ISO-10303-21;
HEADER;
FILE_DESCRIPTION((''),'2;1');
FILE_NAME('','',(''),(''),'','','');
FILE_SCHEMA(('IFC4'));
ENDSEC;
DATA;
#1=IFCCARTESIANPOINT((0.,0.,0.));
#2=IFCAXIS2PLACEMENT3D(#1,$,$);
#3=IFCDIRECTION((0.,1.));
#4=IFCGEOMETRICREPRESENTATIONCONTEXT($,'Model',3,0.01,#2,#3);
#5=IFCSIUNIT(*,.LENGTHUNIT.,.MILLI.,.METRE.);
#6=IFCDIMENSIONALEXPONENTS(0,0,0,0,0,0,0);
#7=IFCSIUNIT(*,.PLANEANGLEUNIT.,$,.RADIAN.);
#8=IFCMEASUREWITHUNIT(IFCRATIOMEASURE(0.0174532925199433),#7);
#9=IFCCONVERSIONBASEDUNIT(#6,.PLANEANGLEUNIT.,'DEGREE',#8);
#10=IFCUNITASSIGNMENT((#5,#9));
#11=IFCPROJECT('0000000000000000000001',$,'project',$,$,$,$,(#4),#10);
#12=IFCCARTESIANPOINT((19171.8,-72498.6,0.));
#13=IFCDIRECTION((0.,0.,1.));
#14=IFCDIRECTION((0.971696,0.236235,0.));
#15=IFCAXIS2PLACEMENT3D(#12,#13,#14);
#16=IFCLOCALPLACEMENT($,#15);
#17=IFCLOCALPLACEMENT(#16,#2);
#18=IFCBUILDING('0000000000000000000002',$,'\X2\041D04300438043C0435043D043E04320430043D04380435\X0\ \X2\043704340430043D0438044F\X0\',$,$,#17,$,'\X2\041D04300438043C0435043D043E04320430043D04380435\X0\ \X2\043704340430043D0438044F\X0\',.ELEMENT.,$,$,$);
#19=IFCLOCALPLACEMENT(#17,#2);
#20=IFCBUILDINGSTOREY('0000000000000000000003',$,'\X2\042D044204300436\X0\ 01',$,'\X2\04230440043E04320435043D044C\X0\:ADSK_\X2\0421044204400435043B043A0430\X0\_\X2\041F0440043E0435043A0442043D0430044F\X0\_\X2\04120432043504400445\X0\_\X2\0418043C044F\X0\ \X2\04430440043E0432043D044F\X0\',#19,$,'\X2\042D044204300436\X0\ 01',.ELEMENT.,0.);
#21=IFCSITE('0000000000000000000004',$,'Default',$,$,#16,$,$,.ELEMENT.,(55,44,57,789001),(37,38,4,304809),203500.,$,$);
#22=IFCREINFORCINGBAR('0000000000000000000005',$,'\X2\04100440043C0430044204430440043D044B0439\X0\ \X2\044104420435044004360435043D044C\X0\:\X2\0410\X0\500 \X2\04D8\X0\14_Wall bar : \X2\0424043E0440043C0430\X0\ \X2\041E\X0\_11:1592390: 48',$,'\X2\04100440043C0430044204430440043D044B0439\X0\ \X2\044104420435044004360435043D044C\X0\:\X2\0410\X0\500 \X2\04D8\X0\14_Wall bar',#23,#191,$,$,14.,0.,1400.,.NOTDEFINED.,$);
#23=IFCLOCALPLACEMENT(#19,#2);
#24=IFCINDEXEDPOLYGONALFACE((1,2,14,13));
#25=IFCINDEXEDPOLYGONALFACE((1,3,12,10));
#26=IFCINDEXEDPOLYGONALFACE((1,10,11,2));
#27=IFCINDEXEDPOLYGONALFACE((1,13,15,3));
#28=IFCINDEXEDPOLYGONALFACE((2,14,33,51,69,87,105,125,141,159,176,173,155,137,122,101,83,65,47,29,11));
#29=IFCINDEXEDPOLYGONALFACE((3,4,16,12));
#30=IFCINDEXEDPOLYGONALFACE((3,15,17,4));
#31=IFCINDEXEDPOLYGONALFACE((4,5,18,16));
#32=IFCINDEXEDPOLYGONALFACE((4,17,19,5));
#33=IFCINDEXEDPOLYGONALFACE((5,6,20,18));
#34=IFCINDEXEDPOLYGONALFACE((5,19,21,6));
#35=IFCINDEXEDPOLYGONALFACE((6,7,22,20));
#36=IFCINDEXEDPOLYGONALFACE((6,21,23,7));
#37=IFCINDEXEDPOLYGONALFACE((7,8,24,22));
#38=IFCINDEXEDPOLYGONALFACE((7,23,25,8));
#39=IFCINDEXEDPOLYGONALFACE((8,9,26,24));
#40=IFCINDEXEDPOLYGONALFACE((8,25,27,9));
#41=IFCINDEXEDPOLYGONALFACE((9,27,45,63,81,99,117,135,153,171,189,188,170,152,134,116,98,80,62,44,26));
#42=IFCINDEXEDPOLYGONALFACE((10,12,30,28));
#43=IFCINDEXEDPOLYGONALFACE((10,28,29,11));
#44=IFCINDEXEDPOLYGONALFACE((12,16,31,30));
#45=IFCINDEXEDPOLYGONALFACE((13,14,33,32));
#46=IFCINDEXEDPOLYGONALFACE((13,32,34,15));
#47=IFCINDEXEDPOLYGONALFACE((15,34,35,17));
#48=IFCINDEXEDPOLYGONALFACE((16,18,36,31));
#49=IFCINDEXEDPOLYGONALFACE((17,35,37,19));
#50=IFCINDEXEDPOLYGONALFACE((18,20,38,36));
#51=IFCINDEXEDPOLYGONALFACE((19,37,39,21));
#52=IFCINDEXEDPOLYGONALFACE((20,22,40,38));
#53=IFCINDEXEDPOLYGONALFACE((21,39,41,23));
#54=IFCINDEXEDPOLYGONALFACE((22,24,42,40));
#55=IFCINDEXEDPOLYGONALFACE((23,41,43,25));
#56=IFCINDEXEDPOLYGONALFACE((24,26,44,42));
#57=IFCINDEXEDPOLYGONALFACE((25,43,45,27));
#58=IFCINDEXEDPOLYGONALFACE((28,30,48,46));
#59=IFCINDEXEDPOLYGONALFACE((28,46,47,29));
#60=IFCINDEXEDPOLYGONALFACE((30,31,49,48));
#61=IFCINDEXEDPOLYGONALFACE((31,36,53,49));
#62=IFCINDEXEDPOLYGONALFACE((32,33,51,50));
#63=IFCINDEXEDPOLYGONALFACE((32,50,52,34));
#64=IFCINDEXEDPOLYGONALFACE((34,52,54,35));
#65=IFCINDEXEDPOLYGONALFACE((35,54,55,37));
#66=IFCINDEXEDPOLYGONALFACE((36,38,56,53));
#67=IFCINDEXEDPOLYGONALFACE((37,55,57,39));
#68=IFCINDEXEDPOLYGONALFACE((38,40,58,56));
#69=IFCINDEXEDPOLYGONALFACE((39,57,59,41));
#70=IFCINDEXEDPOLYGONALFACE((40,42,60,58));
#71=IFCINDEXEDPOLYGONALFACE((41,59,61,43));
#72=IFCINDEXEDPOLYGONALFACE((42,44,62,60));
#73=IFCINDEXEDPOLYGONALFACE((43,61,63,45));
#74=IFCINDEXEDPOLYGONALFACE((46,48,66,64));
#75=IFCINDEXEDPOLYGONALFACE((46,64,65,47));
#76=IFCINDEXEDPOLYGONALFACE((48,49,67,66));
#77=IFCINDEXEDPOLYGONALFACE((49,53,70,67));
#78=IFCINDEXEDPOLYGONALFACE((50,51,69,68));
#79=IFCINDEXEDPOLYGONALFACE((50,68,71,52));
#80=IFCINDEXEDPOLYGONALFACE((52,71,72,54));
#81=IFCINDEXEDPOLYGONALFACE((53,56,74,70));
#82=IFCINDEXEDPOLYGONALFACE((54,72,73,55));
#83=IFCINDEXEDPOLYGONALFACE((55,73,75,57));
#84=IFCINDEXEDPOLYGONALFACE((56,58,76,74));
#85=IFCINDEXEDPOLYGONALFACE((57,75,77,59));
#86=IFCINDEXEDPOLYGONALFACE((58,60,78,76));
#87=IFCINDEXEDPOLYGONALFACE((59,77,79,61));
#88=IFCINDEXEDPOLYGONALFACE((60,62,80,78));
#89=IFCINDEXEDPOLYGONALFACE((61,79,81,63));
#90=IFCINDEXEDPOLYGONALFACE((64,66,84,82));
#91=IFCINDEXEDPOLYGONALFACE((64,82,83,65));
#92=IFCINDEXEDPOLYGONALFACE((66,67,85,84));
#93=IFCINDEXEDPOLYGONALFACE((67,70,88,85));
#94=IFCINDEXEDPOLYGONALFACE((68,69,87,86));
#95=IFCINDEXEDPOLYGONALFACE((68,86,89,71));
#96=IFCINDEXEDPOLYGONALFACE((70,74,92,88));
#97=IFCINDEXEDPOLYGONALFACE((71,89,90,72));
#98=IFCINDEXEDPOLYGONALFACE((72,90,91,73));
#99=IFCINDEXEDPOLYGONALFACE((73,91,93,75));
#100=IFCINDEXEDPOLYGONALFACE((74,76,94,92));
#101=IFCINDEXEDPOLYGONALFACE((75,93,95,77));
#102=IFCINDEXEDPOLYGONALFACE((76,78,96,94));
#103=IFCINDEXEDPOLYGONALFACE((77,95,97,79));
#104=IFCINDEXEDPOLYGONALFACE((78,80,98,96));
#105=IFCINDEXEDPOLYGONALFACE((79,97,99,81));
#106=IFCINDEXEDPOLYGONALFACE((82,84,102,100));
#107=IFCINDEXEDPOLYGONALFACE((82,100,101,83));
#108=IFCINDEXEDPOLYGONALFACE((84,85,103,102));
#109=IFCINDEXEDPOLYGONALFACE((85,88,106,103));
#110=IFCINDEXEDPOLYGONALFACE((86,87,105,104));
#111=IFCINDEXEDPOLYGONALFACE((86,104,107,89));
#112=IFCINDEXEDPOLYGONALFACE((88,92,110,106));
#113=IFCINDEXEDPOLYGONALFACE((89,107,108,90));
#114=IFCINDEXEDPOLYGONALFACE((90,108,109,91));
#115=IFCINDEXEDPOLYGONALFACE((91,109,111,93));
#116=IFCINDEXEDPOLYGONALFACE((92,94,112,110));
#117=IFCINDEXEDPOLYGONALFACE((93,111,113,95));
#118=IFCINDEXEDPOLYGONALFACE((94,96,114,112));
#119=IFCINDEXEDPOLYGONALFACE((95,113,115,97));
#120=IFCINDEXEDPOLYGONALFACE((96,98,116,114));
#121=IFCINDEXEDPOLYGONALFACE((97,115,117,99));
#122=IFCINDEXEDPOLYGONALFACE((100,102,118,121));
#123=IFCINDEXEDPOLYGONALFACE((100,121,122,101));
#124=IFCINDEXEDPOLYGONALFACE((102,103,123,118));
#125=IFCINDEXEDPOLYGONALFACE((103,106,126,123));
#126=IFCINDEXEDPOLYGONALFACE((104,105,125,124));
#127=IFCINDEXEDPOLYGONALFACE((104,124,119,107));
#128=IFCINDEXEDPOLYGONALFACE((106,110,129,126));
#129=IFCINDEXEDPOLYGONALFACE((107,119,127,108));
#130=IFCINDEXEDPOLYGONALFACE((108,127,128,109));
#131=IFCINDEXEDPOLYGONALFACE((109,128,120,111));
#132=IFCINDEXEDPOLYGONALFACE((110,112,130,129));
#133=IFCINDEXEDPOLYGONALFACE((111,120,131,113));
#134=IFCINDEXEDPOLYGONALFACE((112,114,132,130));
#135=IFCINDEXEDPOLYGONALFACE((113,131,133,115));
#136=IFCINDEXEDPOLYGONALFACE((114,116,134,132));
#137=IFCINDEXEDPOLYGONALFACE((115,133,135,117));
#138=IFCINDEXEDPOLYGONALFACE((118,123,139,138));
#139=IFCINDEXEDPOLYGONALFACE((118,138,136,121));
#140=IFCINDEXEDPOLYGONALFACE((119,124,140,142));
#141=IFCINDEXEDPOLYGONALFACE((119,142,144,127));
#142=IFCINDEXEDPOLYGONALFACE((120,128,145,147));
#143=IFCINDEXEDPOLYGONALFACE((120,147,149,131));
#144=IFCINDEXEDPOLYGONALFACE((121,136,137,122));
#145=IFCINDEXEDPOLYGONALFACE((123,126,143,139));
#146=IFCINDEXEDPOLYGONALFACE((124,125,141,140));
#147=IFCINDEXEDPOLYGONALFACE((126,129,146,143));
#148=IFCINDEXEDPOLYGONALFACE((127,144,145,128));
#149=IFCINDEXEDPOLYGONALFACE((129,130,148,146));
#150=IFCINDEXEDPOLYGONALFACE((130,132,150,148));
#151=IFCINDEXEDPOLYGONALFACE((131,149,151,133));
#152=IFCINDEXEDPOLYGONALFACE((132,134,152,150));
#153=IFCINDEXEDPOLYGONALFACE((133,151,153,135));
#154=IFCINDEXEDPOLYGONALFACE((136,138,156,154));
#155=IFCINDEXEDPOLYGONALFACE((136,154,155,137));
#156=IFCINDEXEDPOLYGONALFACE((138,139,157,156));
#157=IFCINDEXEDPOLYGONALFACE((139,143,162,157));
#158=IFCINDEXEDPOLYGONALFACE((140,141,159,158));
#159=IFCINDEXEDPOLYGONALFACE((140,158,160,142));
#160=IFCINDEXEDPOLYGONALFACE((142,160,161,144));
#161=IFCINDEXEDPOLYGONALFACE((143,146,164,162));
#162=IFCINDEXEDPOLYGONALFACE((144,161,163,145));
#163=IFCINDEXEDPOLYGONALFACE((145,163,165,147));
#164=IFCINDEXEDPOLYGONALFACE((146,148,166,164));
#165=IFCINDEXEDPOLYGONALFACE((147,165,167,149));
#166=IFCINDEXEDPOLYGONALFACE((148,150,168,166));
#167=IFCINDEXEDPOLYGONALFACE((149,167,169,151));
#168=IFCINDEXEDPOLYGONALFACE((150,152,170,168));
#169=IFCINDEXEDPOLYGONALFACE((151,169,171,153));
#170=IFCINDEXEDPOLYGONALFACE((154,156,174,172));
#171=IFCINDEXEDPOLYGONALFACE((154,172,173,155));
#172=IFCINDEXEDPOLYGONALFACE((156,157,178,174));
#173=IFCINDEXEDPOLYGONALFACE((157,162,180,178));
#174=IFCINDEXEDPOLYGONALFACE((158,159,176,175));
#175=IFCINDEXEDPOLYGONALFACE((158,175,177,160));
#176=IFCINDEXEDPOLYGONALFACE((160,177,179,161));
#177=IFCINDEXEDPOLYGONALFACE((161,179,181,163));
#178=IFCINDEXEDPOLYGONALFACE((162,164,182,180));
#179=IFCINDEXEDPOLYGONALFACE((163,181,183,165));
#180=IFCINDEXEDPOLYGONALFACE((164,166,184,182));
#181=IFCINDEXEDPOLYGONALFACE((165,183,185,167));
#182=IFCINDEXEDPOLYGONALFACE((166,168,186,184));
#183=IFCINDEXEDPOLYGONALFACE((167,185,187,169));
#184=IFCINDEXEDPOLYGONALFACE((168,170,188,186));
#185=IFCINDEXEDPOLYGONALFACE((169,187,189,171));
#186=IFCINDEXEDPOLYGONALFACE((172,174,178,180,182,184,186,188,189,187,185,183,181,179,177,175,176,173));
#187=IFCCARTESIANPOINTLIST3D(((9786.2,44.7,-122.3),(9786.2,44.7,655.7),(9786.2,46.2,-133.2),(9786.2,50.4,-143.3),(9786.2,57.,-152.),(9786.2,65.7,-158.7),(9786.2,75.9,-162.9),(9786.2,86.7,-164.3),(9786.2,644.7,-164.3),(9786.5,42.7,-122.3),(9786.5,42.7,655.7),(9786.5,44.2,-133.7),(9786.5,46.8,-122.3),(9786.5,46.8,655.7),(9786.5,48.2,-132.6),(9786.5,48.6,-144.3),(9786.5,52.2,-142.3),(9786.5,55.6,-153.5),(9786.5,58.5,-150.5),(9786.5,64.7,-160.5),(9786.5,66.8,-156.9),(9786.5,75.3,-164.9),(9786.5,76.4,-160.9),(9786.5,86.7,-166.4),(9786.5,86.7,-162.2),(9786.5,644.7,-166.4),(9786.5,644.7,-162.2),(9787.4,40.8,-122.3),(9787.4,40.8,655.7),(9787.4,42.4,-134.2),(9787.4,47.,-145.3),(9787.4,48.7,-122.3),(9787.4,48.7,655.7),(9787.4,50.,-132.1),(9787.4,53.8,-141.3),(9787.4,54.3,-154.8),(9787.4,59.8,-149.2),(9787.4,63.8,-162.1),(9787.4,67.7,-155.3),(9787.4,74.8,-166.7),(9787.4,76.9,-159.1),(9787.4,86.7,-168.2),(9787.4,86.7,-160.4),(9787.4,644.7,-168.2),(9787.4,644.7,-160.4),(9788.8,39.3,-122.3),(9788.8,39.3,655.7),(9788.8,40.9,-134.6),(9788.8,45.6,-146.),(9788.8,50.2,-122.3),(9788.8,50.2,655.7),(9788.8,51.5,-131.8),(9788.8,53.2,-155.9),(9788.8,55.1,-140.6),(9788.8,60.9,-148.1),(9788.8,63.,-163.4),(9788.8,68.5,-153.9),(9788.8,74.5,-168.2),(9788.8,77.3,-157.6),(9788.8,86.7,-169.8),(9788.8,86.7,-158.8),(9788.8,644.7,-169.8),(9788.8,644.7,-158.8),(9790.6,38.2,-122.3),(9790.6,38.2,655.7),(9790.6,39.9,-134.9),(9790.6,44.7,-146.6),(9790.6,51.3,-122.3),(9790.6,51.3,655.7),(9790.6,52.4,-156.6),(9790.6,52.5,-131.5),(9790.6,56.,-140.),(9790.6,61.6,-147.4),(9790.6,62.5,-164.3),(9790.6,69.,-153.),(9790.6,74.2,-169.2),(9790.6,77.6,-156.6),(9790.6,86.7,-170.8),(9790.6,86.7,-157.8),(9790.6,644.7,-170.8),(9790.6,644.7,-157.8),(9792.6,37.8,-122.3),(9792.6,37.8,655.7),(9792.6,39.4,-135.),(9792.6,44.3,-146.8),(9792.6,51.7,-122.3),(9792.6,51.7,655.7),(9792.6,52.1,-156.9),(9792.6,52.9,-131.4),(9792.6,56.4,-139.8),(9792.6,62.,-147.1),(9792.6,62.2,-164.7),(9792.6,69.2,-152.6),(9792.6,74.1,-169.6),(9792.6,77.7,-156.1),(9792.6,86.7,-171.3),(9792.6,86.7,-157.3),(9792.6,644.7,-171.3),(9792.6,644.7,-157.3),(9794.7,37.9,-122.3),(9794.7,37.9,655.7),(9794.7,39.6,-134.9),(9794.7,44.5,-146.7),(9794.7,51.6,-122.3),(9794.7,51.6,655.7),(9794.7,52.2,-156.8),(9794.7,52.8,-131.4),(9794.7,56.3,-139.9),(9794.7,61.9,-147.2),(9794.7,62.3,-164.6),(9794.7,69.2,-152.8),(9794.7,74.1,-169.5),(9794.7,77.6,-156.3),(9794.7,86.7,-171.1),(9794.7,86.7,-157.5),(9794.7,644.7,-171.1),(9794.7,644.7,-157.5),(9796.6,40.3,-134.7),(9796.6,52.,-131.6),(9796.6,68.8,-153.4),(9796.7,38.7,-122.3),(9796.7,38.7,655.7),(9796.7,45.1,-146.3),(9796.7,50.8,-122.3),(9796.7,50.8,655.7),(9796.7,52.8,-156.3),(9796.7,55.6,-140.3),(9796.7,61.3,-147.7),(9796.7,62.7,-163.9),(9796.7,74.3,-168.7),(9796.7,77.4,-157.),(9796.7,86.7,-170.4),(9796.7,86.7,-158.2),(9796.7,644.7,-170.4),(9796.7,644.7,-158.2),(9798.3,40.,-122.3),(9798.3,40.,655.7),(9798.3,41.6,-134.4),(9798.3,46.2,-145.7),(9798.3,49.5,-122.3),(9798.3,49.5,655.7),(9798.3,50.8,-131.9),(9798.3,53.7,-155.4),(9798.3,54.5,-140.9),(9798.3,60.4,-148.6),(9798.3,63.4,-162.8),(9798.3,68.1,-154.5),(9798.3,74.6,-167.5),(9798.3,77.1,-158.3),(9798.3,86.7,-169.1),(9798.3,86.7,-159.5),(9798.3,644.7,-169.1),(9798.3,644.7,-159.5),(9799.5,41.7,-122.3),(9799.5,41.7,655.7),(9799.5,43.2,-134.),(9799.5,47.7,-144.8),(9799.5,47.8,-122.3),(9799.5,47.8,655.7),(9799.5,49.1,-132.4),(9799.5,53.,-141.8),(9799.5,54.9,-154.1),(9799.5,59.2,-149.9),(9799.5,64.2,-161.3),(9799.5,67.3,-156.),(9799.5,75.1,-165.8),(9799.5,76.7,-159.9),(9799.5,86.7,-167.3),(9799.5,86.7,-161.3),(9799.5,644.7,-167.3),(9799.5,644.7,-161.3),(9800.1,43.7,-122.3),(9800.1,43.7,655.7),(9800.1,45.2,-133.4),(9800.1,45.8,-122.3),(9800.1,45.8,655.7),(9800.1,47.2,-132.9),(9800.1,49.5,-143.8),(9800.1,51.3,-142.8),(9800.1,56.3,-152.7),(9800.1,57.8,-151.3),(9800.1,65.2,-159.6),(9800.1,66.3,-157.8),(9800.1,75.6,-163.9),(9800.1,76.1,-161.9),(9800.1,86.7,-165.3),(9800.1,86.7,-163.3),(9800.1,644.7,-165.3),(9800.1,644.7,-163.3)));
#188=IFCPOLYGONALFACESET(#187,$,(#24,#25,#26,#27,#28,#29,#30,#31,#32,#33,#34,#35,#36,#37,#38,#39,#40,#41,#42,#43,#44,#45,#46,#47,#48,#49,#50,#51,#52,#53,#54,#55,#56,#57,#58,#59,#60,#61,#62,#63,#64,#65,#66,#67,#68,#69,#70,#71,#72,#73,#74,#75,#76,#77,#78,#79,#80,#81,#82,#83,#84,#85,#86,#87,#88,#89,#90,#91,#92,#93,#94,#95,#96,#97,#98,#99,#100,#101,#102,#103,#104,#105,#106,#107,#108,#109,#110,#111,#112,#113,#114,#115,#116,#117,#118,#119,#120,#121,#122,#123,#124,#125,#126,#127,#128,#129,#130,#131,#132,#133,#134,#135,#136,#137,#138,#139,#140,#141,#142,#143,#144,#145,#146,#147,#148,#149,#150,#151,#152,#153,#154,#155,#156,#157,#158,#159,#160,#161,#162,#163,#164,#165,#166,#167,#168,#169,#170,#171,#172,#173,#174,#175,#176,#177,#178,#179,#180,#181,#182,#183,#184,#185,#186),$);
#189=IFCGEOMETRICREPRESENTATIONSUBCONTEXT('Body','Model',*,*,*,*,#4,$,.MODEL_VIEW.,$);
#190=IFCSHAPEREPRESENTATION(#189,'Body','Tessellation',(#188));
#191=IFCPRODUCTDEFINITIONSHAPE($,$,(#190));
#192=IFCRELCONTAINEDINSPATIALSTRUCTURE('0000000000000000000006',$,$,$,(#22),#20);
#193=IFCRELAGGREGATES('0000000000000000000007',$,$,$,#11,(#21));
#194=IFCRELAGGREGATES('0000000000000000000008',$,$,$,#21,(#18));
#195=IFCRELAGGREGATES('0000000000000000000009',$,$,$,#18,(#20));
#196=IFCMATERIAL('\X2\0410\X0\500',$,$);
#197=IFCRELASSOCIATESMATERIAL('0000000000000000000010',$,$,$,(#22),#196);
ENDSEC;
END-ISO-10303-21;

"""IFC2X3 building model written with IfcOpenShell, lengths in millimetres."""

from ifc_helpers import new_model, entity, si_unit, converted_unit, direction, frame, origin, place, context, subcontext, project, spatial, material, element, save


model = new_model("IFC2X3")

# Units and contexts
model_context = context("Model", 3, precision=0.01, world=origin(), true_north=direction((0.0, 1.0)))
body_context = subcontext(model_context, "Body", "Model", "MODEL_VIEW")
ifc_project = project(units=[si_unit("LENGTHUNIT", "METRE", prefix="MILLI"), converted_unit("PLANEANGLEUNIT", "DEGREE", entity("IfcRatioMeasure", 0.0174532925199433), si_unit("PLANEANGLEUNIT", "RADIAN"), dimensions=[0, 0, 0, 0, 0, 0, 0])], contexts=[model_context])

# Site, building, storey
site_placement = place(None, frame((19171.8, -72498.6, 0.0), z_axis=(0.0, 0.0, 1.0), x_axis=(0.971696, 0.236235, 0.0)))
site = spatial("IfcSite", under=ifc_project, at=site_placement, Name="Default", CompositionType="ELEMENT", RefLatitude=(55, 44, 57, 789001), RefLongitude=(37, 38, 4, 304809), RefElevation=203500.0)
building_placement = place(site_placement, origin())
building = spatial("IfcBuilding", under=site, at=building_placement, Name="Наименование здания", LongName="Наименование здания", CompositionType="ELEMENT")
storey_placement = place(building_placement, origin())
storey = spatial("IfcBuildingStorey", under=building, at=storey_placement, Name="Этаж 01", ObjectType="Уровень:ADSK_Стрелка_Проектная_Вверх_Имя уровня", LongName="Этаж 01", CompositionType="ELEMENT", Elevation=0.0)

# Reinforcing bar
ifc_material = material(Name="А500")
placement = place(storey_placement, origin())
element("IfcReinforcingBar", 1, at=placement, inside=storey, material=ifc_material, Name="Арматурный стержень:А500 Ә14_Wall bar : Форма О_11:1592390: 48", ObjectType="Арматурный стержень:А500 Ә14_Wall bar", BarLength=1400.0, BarRole="NOTDEFINED", CrossSectionArea=0.0, NominalDiameter=14.0, context=body_context, shape_type="AdvancedSweptSolid", body=[
    entity("IfcSweptDiskSolid", entity("IfcCompositeCurve", [entity("IfcCompositeCurveSegment", "CONTINUOUS", True, entity("IfcPolyline", [entity("IfcCartesianPoint", [9793.1, 44.7, 655.7]), entity("IfcCartesianPoint", [9793.1, 44.7, -122.3])])), entity("IfcCompositeCurveSegment", "CONTINUOUS", True, entity("IfcTrimmedCurve", entity("IfcCircle", entity("IfcAxis2Placement3D", entity("IfcCartesianPoint", [9793.1, 86.7, -122.3]), entity("IfcDirection", [1.0, 0.0, 0.0]), entity("IfcDirection", [0.0, 0.0, -1.0])), 42.0), [entity("IfcParameterValue", 270.0)], [entity("IfcParameterValue", 360.0)], True, "PARAMETER")), entity("IfcCompositeCurveSegment", "CONTINUOUS", True, entity("IfcPolyline", [entity("IfcCartesianPoint", [9793.1, 86.7, -164.3]), entity("IfcCartesianPoint", [9793.1, 644.7, -164.3])]))], False), 7.0, None, 0.0, 92.0),
])

save(model, "model.ifc")
